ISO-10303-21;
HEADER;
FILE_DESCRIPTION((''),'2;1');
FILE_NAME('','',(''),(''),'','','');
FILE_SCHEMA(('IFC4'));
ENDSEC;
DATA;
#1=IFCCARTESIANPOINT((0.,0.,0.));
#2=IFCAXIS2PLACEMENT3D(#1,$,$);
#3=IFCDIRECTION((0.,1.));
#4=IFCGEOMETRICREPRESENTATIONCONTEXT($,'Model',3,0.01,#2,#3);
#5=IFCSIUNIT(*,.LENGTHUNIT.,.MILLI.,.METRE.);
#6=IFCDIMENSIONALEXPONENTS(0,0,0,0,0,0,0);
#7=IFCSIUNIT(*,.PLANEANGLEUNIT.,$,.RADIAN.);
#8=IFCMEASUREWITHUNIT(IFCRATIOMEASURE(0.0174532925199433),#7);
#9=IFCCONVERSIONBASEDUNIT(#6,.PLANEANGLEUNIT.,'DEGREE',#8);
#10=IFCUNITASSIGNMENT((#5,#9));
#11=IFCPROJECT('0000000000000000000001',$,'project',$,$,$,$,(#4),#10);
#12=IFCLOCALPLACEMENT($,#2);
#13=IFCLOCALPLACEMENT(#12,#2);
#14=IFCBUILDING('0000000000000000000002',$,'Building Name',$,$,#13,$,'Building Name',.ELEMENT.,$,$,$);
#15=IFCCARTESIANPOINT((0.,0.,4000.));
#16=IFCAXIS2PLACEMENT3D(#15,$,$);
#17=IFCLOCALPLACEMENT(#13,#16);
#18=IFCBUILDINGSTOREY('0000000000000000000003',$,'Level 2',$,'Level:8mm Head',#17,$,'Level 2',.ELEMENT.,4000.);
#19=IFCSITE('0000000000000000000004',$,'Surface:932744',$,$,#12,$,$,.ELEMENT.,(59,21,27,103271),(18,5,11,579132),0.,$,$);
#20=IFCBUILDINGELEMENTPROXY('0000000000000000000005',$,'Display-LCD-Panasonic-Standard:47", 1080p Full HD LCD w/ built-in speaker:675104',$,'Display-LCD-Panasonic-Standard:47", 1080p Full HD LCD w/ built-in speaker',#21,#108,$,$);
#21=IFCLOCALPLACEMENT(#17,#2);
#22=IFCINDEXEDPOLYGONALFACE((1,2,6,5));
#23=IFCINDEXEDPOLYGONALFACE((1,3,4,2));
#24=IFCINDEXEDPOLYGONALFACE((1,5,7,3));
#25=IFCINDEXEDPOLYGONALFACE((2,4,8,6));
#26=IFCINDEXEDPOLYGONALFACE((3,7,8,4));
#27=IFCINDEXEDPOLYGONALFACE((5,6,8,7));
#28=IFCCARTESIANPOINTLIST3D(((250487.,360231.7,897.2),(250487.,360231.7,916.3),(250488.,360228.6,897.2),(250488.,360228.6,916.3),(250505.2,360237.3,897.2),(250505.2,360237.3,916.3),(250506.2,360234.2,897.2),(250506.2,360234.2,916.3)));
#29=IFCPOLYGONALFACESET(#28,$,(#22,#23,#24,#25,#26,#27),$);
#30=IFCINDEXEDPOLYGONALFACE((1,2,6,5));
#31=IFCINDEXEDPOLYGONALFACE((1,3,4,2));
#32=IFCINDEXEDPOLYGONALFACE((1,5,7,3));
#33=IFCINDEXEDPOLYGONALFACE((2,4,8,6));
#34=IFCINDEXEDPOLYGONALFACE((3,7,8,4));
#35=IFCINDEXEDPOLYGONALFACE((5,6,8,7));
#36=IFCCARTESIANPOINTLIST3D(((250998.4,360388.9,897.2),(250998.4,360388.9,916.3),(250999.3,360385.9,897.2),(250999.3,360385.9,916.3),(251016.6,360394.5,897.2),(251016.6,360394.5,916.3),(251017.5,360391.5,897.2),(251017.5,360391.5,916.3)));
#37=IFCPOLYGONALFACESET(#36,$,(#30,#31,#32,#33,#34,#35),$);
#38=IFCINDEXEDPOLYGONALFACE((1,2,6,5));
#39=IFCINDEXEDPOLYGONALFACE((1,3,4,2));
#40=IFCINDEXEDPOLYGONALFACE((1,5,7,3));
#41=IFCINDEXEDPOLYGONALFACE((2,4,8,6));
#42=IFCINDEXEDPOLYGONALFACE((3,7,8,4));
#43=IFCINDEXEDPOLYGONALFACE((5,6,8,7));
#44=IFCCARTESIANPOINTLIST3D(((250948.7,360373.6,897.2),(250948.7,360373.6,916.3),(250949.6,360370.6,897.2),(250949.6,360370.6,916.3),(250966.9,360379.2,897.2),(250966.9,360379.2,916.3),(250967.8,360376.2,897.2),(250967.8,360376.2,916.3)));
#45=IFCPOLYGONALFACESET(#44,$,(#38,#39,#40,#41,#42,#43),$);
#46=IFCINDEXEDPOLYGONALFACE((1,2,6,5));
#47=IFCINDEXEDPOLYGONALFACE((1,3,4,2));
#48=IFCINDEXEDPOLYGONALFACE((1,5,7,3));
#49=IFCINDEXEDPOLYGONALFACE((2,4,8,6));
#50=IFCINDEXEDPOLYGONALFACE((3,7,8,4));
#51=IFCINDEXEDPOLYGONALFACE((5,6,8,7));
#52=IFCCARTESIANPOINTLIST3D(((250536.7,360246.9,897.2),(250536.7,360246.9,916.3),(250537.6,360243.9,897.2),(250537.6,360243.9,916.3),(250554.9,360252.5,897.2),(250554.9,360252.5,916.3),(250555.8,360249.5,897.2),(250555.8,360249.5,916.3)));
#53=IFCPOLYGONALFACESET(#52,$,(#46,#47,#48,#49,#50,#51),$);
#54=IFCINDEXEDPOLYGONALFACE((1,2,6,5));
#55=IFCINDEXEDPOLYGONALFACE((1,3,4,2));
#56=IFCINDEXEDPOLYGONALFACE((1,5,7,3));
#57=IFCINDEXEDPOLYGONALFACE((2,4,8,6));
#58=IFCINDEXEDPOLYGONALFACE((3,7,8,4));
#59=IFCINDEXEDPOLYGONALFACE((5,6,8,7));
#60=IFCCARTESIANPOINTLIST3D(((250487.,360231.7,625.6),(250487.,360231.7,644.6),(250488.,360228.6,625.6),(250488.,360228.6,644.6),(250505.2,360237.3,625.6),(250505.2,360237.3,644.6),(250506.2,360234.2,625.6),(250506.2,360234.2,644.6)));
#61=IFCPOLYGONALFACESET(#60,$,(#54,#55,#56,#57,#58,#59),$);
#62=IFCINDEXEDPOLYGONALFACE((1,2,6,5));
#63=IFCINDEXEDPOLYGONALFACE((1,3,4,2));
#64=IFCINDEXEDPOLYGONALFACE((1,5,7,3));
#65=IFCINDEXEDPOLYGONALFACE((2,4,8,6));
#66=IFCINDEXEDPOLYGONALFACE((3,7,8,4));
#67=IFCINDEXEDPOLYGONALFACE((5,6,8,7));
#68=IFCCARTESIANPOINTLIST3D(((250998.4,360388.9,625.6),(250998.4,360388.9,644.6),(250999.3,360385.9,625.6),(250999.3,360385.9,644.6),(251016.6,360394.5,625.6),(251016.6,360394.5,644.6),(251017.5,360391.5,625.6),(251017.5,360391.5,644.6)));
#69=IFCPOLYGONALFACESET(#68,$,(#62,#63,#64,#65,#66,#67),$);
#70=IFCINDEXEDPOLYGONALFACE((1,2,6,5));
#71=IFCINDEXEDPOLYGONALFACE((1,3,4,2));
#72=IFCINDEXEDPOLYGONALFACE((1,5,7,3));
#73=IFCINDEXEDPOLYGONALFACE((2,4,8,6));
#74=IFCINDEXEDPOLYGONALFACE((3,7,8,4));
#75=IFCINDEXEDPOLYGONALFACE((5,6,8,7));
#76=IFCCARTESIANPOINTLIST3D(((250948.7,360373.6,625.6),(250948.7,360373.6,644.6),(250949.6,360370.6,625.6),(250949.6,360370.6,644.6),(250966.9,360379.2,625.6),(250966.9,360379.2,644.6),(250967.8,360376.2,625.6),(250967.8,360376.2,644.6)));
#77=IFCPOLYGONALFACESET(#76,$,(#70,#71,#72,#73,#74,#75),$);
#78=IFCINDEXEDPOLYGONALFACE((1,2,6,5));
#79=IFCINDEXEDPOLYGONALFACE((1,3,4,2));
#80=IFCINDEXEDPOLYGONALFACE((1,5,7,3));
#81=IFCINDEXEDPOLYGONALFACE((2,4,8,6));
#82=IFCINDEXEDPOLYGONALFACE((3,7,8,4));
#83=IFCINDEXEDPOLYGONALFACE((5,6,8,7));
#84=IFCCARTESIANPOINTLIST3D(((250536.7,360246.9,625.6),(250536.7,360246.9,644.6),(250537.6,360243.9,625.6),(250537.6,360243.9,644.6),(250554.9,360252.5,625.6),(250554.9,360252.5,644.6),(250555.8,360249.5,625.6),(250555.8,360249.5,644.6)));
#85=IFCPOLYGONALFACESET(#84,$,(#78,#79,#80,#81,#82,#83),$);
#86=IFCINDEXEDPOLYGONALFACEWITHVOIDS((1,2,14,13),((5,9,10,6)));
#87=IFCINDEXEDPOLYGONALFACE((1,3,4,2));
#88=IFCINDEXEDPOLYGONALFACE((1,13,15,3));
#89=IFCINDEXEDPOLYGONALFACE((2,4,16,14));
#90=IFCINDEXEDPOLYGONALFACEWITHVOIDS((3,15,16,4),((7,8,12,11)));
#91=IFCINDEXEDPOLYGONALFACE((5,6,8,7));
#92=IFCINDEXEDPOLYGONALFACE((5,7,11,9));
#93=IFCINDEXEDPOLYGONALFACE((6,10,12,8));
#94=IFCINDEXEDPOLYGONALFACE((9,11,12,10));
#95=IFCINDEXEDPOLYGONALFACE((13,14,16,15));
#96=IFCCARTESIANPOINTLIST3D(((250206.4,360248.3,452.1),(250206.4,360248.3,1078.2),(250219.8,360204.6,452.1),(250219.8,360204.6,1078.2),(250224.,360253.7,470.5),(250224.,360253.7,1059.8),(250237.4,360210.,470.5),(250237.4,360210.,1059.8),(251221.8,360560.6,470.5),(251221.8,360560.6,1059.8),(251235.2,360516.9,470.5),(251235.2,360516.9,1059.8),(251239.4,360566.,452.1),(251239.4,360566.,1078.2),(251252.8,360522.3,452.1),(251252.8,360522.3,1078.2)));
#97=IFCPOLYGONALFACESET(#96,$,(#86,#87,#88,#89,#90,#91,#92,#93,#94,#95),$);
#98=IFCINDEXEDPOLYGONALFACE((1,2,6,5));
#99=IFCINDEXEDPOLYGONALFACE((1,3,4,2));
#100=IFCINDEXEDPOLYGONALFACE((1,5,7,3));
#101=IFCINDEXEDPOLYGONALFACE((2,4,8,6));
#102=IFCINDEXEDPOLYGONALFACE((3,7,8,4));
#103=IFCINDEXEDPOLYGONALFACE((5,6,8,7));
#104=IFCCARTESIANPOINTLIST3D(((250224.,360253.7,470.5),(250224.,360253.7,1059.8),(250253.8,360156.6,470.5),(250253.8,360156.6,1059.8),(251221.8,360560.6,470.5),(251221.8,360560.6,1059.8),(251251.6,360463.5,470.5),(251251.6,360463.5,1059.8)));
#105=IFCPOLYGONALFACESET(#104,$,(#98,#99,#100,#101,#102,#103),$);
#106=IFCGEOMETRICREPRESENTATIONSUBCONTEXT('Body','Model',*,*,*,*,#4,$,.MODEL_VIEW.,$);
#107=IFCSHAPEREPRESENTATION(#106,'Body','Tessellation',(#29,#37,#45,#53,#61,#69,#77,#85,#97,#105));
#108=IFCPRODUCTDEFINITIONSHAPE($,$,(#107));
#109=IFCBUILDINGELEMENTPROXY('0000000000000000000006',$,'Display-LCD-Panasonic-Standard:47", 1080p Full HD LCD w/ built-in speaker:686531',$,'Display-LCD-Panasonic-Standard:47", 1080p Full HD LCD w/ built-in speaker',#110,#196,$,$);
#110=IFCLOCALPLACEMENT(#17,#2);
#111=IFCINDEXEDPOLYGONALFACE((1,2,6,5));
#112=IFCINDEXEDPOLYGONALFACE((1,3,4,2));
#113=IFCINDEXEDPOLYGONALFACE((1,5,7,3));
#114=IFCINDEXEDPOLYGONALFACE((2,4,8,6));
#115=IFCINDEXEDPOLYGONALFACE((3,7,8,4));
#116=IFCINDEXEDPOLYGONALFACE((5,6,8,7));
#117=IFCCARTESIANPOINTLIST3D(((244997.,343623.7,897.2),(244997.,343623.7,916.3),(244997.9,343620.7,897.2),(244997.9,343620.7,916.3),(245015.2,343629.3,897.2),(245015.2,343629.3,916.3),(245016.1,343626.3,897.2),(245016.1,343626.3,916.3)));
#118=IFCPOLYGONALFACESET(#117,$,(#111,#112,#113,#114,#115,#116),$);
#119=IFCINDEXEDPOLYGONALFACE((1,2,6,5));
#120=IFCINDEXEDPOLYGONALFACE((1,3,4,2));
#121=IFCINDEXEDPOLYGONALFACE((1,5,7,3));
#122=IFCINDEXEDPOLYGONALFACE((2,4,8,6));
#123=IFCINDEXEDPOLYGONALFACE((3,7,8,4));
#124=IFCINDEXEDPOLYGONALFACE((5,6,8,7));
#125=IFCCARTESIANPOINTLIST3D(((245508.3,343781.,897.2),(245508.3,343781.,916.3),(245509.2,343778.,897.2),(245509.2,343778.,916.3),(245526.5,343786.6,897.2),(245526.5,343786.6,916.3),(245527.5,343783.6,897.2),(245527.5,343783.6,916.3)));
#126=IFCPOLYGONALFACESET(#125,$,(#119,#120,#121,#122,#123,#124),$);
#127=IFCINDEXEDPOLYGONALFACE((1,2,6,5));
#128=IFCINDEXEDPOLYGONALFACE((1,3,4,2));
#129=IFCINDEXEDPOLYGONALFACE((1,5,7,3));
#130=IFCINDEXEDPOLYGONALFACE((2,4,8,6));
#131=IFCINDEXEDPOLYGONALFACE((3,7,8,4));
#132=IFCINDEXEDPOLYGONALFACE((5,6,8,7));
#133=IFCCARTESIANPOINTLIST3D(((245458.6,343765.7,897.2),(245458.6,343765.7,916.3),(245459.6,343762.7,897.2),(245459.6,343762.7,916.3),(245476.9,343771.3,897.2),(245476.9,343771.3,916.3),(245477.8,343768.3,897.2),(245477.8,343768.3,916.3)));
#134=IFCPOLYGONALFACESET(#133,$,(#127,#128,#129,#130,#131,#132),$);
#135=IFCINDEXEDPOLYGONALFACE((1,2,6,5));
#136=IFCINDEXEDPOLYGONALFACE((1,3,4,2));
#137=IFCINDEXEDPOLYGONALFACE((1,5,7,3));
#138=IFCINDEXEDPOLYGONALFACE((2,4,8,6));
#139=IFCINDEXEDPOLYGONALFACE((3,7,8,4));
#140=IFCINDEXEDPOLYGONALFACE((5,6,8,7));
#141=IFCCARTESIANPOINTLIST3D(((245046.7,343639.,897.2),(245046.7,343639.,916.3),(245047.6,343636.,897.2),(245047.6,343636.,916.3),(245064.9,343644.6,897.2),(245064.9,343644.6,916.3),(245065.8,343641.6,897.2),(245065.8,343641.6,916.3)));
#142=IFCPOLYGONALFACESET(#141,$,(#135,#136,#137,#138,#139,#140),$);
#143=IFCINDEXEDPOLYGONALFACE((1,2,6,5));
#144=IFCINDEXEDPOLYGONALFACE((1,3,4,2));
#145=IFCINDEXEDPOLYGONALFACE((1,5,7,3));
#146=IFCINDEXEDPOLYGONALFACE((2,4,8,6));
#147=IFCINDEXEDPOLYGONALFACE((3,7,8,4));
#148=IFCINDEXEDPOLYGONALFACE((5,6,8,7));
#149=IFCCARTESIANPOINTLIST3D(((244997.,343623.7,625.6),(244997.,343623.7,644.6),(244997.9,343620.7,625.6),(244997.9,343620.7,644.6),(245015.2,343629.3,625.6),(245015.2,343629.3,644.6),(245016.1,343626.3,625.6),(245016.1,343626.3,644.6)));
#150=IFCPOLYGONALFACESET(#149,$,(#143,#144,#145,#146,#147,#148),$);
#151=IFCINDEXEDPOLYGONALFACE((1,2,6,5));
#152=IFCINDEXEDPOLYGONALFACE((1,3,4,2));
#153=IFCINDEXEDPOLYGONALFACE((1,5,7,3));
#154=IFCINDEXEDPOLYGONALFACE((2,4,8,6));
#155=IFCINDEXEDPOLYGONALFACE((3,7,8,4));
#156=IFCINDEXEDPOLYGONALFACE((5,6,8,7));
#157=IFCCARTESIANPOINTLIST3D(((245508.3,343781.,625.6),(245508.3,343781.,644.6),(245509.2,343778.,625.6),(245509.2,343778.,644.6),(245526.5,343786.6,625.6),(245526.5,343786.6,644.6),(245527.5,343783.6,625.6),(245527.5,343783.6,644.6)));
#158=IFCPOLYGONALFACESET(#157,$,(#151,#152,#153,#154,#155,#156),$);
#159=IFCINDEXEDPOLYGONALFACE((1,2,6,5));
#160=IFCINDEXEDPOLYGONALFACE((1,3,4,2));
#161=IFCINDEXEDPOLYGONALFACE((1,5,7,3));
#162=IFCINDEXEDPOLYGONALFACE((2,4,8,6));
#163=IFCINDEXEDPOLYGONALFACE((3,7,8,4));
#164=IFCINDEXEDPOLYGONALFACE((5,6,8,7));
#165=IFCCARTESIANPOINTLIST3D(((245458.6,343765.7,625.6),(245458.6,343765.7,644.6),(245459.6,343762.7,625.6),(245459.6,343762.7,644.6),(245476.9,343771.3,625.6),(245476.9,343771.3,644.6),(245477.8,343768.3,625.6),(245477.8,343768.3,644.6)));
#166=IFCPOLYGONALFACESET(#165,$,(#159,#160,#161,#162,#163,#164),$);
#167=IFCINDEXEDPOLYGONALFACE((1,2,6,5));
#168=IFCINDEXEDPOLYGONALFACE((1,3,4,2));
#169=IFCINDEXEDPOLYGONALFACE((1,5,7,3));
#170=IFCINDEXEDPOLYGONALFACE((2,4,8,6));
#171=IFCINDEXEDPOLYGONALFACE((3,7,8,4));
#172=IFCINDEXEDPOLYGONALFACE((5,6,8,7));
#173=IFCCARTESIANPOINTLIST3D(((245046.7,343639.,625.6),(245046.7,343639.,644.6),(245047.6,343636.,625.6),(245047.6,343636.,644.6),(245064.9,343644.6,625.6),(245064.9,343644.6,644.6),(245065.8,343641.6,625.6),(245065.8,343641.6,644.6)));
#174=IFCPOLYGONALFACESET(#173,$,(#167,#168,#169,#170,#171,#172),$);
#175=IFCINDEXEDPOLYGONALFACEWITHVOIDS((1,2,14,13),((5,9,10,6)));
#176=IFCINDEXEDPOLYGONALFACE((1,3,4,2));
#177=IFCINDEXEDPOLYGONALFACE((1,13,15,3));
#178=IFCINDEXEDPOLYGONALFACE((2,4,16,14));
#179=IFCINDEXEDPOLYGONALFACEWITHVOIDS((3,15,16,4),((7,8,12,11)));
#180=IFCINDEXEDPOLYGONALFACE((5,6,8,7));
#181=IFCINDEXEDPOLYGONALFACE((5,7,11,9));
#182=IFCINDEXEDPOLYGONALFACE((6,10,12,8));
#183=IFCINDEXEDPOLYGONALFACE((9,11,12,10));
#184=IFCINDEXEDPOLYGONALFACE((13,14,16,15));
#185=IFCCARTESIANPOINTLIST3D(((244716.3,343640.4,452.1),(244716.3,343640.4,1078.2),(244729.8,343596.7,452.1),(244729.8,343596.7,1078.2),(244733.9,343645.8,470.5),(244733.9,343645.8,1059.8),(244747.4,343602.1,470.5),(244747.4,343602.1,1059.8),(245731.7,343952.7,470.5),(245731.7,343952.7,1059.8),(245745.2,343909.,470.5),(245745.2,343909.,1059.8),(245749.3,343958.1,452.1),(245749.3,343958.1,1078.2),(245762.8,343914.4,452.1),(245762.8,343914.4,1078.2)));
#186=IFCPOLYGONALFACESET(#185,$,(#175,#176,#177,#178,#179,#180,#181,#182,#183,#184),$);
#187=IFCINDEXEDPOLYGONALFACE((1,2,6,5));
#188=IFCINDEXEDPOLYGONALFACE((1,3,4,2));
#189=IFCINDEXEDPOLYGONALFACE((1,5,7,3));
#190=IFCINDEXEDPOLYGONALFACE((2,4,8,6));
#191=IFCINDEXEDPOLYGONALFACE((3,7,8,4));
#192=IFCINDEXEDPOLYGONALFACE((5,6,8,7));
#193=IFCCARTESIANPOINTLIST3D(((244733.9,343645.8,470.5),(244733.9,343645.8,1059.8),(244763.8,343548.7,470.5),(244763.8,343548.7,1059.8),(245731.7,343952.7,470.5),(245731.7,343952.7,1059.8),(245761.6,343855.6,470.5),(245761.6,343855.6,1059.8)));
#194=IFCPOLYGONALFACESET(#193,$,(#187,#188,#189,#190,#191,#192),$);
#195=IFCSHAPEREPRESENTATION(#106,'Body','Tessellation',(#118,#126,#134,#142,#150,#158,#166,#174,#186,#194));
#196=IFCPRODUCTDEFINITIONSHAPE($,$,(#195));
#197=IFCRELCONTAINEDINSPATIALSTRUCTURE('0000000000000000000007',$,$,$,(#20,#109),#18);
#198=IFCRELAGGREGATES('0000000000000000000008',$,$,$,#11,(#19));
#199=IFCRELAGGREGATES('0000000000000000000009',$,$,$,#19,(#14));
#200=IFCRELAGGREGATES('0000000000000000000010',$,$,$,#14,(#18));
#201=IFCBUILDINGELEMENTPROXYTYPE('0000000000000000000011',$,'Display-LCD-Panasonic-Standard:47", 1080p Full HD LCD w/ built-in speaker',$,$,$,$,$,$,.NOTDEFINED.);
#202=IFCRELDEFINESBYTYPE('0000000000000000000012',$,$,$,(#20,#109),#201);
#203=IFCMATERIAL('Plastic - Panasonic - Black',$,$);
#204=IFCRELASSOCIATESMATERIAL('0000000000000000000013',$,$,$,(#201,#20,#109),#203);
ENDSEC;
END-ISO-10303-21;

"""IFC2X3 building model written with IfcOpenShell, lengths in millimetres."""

from ifc_helpers import new_model, entity, si_unit, converted_unit, direction, frame, frame_2d, origin, origin_2d_with_axis, place, context, subcontext, project, spatial, polyline, rectangle, outline, extrude, source, transform, mapped, material, type_object, type_shapes, element, save


model = new_model("IFC2X3")

# Units and contexts
model_context = context("Model", 3, precision=0.01, world=origin(), true_north=direction((0.0, 1.0)))
body_context = subcontext(model_context, "Body", "Model", "MODEL_VIEW")
ifc_project = project(units=[si_unit("LENGTHUNIT", "METRE", prefix="MILLI"), converted_unit("PLANEANGLEUNIT", "DEGREE", entity("IfcRatioMeasure", 0.0174532925199433), si_unit("PLANEANGLEUNIT", "RADIAN"), dimensions=[0, 0, 0, 0, 0, 0, 0])], contexts=[model_context])

# Site, building, storey
site_placement = place(None, origin())
site = spatial("IfcSite", under=ifc_project, at=site_placement, Name="Surface:932744", CompositionType="ELEMENT", RefLatitude=(59, 21, 27, 103271), RefLongitude=(18, 5, 11, 579132), RefElevation=0.0)
building_placement = place(site_placement, origin())
building = spatial("IfcBuilding", under=site, at=building_placement, Name="Building Name", LongName="Building Name", CompositionType="ELEMENT")
storey_placement = place(building_placement, frame((0.0, 0.0, 4000.0)))
storey = spatial("IfcBuildingStorey", under=building, at=storey_placement, Name="Level 2", ObjectType="Level:8mm Head", LongName="Level 2", CompositionType="ELEMENT", Elevation=4000.0)

# Building element proxies
ifc_material = material(Name="Plastic - Panasonic - Black")
building_element_proxy_type = type_object("IfcBuildingElementProxyType", Name="Display-LCD-Panasonic-Standard:47\", 1080p Full HD LCD w/ built-in speaker", PredefinedType="NOTDEFINED", material=ifc_material)
shared_shape = source(origin(), body_context, "Body", "SweptSolid", [
    extrude(rectangle(XDim=19.0, YDim=19.1, at=origin_2d_with_axis()), frame((267.5, 187.5, 0.0), z_axis=(0.0, 0.0, 1.0), x_axis=(0.0, 1.0, 0.0)), (0.0, 0.0, 1.0), 3.2),
    extrude(rectangle(XDim=19.0, YDim=19.1, at=origin_2d_with_axis()), frame((-267.5, 187.5, 0.0), z_axis=(0.0, 0.0, 1.0), x_axis=(0.0, 1.0, 0.0)), (0.0, 0.0, 1.0), 3.2),
    extrude(rectangle(XDim=19.0, YDim=19.0, at=origin_2d_with_axis()), frame((-215.5, 187.5, 0.0), z_axis=(0.0, 0.0, 1.0), x_axis=(0.0, 1.0, 0.0)), (0.0, 0.0, 1.0), 3.2),
    extrude(rectangle(XDim=19.0, YDim=19.0, at=frame_2d((0.0, 0.0), x_axis=(1.0, 0.0))), frame((215.5, 187.5, 0.0), z_axis=(0.0, 0.0, 1.0), x_axis=(0.0, 1.0, 0.0)), (0.0, 0.0, 1.0), 3.2),
    extrude(rectangle(XDim=19.0, YDim=19.1, at=frame_2d((0.0, 0.0), x_axis=(1.0, 0.0))), frame((267.5, -84.1, 0.0), z_axis=(0.0, 0.0, 1.0), x_axis=(0.0, 1.0, 0.0)), (0.0, 0.0, 1.0), 3.2),
    extrude(rectangle(XDim=19.0, YDim=19.1, at=frame_2d((0.0, 0.0), x_axis=(1.0, 0.0))), frame((-267.5, -84.1, 0.0), z_axis=(0.0, 0.0, 1.0), x_axis=(0.0, 1.0, 0.0)), (0.0, 0.0, 1.0), 3.2),
    extrude(rectangle(XDim=19.0, YDim=19.0, at=frame_2d((0.0, 0.0), x_axis=(1.0, 0.0))), frame((-215.5, -84.1, 0.0), z_axis=(0.0, 0.0, 1.0), x_axis=(0.0, 1.0, 0.0)), (0.0, 0.0, 1.0), 3.2),
    extrude(rectangle(XDim=19.0, YDim=19.0, at=frame_2d((0.0, 0.0), x_axis=(1.0, 0.0))), frame((215.5, -84.1, 0.0), z_axis=(0.0, 0.0, 1.0), x_axis=(0.0, 1.0, 0.0)), (0.0, 0.0, 1.0), 3.2),
    extrude(outline(polyline([(-313.1, -540.4), (313.1, -540.4), (313.1, 540.4), (-313.1, 540.4), (-313.1, -540.4)]), holes=[polyline([(294.6, -522.0), (-294.6, -522.0), (-294.6, 522.0), (294.6, 522.0), (294.6, -522.0)])]), frame((0.0, 46.0, 55.9), z_axis=(0.0, 0.0, 1.0), x_axis=(0.0, 1.0, 0.0)), (0.0, 0.0, 1.0), 45.7),
    extrude(rectangle(XDim=1043.9, YDim=589.3, at=frame_2d((0.0, 0.0), x_axis=(1.0, 0.0))), frame((0.0, 46.0, 0.0), z_axis=(0.0, 0.0, 1.0), x_axis=(-1.0, 0.0, 0.0)), (0.0, 0.0, 1.0), 101.6),
])
type_shapes(building_element_proxy_type, [shared_shape])
for number, where, z_axis, x_axis, name in (
    (1, (250752.7, 360310.1, 719.2), (-0.29398, 0.955811, 0.0), (-0.955811, -0.29398, 0.0), "Display-LCD-Panasonic-Standard:47\", 1080p Full HD LCD w/ built-in speaker:675104"),
    (2, (245262.7, 343702.1, 719.2), (-0.29398, 0.955811, 0.0), (-0.955811, -0.29398, 0.0), "Display-LCD-Panasonic-Standard:47\", 1080p Full HD LCD w/ built-in speaker:686531"),
):
    element("IfcBuildingElementProxy", number, at=place(storey_placement, frame(where, z_axis=z_axis, x_axis=x_axis)), inside=storey, type_object=building_element_proxy_type, material=ifc_material, Name=name, ObjectType="Display-LCD-Panasonic-Standard:47\", 1080p Full HD LCD w/ built-in speaker", context=body_context, shape_type="MappedRepresentation", body=[
        mapped(shared_shape, transform((0.0, 0.0, 0.0), scale=1.0)),
    ])

save(model, "model.ifc")
